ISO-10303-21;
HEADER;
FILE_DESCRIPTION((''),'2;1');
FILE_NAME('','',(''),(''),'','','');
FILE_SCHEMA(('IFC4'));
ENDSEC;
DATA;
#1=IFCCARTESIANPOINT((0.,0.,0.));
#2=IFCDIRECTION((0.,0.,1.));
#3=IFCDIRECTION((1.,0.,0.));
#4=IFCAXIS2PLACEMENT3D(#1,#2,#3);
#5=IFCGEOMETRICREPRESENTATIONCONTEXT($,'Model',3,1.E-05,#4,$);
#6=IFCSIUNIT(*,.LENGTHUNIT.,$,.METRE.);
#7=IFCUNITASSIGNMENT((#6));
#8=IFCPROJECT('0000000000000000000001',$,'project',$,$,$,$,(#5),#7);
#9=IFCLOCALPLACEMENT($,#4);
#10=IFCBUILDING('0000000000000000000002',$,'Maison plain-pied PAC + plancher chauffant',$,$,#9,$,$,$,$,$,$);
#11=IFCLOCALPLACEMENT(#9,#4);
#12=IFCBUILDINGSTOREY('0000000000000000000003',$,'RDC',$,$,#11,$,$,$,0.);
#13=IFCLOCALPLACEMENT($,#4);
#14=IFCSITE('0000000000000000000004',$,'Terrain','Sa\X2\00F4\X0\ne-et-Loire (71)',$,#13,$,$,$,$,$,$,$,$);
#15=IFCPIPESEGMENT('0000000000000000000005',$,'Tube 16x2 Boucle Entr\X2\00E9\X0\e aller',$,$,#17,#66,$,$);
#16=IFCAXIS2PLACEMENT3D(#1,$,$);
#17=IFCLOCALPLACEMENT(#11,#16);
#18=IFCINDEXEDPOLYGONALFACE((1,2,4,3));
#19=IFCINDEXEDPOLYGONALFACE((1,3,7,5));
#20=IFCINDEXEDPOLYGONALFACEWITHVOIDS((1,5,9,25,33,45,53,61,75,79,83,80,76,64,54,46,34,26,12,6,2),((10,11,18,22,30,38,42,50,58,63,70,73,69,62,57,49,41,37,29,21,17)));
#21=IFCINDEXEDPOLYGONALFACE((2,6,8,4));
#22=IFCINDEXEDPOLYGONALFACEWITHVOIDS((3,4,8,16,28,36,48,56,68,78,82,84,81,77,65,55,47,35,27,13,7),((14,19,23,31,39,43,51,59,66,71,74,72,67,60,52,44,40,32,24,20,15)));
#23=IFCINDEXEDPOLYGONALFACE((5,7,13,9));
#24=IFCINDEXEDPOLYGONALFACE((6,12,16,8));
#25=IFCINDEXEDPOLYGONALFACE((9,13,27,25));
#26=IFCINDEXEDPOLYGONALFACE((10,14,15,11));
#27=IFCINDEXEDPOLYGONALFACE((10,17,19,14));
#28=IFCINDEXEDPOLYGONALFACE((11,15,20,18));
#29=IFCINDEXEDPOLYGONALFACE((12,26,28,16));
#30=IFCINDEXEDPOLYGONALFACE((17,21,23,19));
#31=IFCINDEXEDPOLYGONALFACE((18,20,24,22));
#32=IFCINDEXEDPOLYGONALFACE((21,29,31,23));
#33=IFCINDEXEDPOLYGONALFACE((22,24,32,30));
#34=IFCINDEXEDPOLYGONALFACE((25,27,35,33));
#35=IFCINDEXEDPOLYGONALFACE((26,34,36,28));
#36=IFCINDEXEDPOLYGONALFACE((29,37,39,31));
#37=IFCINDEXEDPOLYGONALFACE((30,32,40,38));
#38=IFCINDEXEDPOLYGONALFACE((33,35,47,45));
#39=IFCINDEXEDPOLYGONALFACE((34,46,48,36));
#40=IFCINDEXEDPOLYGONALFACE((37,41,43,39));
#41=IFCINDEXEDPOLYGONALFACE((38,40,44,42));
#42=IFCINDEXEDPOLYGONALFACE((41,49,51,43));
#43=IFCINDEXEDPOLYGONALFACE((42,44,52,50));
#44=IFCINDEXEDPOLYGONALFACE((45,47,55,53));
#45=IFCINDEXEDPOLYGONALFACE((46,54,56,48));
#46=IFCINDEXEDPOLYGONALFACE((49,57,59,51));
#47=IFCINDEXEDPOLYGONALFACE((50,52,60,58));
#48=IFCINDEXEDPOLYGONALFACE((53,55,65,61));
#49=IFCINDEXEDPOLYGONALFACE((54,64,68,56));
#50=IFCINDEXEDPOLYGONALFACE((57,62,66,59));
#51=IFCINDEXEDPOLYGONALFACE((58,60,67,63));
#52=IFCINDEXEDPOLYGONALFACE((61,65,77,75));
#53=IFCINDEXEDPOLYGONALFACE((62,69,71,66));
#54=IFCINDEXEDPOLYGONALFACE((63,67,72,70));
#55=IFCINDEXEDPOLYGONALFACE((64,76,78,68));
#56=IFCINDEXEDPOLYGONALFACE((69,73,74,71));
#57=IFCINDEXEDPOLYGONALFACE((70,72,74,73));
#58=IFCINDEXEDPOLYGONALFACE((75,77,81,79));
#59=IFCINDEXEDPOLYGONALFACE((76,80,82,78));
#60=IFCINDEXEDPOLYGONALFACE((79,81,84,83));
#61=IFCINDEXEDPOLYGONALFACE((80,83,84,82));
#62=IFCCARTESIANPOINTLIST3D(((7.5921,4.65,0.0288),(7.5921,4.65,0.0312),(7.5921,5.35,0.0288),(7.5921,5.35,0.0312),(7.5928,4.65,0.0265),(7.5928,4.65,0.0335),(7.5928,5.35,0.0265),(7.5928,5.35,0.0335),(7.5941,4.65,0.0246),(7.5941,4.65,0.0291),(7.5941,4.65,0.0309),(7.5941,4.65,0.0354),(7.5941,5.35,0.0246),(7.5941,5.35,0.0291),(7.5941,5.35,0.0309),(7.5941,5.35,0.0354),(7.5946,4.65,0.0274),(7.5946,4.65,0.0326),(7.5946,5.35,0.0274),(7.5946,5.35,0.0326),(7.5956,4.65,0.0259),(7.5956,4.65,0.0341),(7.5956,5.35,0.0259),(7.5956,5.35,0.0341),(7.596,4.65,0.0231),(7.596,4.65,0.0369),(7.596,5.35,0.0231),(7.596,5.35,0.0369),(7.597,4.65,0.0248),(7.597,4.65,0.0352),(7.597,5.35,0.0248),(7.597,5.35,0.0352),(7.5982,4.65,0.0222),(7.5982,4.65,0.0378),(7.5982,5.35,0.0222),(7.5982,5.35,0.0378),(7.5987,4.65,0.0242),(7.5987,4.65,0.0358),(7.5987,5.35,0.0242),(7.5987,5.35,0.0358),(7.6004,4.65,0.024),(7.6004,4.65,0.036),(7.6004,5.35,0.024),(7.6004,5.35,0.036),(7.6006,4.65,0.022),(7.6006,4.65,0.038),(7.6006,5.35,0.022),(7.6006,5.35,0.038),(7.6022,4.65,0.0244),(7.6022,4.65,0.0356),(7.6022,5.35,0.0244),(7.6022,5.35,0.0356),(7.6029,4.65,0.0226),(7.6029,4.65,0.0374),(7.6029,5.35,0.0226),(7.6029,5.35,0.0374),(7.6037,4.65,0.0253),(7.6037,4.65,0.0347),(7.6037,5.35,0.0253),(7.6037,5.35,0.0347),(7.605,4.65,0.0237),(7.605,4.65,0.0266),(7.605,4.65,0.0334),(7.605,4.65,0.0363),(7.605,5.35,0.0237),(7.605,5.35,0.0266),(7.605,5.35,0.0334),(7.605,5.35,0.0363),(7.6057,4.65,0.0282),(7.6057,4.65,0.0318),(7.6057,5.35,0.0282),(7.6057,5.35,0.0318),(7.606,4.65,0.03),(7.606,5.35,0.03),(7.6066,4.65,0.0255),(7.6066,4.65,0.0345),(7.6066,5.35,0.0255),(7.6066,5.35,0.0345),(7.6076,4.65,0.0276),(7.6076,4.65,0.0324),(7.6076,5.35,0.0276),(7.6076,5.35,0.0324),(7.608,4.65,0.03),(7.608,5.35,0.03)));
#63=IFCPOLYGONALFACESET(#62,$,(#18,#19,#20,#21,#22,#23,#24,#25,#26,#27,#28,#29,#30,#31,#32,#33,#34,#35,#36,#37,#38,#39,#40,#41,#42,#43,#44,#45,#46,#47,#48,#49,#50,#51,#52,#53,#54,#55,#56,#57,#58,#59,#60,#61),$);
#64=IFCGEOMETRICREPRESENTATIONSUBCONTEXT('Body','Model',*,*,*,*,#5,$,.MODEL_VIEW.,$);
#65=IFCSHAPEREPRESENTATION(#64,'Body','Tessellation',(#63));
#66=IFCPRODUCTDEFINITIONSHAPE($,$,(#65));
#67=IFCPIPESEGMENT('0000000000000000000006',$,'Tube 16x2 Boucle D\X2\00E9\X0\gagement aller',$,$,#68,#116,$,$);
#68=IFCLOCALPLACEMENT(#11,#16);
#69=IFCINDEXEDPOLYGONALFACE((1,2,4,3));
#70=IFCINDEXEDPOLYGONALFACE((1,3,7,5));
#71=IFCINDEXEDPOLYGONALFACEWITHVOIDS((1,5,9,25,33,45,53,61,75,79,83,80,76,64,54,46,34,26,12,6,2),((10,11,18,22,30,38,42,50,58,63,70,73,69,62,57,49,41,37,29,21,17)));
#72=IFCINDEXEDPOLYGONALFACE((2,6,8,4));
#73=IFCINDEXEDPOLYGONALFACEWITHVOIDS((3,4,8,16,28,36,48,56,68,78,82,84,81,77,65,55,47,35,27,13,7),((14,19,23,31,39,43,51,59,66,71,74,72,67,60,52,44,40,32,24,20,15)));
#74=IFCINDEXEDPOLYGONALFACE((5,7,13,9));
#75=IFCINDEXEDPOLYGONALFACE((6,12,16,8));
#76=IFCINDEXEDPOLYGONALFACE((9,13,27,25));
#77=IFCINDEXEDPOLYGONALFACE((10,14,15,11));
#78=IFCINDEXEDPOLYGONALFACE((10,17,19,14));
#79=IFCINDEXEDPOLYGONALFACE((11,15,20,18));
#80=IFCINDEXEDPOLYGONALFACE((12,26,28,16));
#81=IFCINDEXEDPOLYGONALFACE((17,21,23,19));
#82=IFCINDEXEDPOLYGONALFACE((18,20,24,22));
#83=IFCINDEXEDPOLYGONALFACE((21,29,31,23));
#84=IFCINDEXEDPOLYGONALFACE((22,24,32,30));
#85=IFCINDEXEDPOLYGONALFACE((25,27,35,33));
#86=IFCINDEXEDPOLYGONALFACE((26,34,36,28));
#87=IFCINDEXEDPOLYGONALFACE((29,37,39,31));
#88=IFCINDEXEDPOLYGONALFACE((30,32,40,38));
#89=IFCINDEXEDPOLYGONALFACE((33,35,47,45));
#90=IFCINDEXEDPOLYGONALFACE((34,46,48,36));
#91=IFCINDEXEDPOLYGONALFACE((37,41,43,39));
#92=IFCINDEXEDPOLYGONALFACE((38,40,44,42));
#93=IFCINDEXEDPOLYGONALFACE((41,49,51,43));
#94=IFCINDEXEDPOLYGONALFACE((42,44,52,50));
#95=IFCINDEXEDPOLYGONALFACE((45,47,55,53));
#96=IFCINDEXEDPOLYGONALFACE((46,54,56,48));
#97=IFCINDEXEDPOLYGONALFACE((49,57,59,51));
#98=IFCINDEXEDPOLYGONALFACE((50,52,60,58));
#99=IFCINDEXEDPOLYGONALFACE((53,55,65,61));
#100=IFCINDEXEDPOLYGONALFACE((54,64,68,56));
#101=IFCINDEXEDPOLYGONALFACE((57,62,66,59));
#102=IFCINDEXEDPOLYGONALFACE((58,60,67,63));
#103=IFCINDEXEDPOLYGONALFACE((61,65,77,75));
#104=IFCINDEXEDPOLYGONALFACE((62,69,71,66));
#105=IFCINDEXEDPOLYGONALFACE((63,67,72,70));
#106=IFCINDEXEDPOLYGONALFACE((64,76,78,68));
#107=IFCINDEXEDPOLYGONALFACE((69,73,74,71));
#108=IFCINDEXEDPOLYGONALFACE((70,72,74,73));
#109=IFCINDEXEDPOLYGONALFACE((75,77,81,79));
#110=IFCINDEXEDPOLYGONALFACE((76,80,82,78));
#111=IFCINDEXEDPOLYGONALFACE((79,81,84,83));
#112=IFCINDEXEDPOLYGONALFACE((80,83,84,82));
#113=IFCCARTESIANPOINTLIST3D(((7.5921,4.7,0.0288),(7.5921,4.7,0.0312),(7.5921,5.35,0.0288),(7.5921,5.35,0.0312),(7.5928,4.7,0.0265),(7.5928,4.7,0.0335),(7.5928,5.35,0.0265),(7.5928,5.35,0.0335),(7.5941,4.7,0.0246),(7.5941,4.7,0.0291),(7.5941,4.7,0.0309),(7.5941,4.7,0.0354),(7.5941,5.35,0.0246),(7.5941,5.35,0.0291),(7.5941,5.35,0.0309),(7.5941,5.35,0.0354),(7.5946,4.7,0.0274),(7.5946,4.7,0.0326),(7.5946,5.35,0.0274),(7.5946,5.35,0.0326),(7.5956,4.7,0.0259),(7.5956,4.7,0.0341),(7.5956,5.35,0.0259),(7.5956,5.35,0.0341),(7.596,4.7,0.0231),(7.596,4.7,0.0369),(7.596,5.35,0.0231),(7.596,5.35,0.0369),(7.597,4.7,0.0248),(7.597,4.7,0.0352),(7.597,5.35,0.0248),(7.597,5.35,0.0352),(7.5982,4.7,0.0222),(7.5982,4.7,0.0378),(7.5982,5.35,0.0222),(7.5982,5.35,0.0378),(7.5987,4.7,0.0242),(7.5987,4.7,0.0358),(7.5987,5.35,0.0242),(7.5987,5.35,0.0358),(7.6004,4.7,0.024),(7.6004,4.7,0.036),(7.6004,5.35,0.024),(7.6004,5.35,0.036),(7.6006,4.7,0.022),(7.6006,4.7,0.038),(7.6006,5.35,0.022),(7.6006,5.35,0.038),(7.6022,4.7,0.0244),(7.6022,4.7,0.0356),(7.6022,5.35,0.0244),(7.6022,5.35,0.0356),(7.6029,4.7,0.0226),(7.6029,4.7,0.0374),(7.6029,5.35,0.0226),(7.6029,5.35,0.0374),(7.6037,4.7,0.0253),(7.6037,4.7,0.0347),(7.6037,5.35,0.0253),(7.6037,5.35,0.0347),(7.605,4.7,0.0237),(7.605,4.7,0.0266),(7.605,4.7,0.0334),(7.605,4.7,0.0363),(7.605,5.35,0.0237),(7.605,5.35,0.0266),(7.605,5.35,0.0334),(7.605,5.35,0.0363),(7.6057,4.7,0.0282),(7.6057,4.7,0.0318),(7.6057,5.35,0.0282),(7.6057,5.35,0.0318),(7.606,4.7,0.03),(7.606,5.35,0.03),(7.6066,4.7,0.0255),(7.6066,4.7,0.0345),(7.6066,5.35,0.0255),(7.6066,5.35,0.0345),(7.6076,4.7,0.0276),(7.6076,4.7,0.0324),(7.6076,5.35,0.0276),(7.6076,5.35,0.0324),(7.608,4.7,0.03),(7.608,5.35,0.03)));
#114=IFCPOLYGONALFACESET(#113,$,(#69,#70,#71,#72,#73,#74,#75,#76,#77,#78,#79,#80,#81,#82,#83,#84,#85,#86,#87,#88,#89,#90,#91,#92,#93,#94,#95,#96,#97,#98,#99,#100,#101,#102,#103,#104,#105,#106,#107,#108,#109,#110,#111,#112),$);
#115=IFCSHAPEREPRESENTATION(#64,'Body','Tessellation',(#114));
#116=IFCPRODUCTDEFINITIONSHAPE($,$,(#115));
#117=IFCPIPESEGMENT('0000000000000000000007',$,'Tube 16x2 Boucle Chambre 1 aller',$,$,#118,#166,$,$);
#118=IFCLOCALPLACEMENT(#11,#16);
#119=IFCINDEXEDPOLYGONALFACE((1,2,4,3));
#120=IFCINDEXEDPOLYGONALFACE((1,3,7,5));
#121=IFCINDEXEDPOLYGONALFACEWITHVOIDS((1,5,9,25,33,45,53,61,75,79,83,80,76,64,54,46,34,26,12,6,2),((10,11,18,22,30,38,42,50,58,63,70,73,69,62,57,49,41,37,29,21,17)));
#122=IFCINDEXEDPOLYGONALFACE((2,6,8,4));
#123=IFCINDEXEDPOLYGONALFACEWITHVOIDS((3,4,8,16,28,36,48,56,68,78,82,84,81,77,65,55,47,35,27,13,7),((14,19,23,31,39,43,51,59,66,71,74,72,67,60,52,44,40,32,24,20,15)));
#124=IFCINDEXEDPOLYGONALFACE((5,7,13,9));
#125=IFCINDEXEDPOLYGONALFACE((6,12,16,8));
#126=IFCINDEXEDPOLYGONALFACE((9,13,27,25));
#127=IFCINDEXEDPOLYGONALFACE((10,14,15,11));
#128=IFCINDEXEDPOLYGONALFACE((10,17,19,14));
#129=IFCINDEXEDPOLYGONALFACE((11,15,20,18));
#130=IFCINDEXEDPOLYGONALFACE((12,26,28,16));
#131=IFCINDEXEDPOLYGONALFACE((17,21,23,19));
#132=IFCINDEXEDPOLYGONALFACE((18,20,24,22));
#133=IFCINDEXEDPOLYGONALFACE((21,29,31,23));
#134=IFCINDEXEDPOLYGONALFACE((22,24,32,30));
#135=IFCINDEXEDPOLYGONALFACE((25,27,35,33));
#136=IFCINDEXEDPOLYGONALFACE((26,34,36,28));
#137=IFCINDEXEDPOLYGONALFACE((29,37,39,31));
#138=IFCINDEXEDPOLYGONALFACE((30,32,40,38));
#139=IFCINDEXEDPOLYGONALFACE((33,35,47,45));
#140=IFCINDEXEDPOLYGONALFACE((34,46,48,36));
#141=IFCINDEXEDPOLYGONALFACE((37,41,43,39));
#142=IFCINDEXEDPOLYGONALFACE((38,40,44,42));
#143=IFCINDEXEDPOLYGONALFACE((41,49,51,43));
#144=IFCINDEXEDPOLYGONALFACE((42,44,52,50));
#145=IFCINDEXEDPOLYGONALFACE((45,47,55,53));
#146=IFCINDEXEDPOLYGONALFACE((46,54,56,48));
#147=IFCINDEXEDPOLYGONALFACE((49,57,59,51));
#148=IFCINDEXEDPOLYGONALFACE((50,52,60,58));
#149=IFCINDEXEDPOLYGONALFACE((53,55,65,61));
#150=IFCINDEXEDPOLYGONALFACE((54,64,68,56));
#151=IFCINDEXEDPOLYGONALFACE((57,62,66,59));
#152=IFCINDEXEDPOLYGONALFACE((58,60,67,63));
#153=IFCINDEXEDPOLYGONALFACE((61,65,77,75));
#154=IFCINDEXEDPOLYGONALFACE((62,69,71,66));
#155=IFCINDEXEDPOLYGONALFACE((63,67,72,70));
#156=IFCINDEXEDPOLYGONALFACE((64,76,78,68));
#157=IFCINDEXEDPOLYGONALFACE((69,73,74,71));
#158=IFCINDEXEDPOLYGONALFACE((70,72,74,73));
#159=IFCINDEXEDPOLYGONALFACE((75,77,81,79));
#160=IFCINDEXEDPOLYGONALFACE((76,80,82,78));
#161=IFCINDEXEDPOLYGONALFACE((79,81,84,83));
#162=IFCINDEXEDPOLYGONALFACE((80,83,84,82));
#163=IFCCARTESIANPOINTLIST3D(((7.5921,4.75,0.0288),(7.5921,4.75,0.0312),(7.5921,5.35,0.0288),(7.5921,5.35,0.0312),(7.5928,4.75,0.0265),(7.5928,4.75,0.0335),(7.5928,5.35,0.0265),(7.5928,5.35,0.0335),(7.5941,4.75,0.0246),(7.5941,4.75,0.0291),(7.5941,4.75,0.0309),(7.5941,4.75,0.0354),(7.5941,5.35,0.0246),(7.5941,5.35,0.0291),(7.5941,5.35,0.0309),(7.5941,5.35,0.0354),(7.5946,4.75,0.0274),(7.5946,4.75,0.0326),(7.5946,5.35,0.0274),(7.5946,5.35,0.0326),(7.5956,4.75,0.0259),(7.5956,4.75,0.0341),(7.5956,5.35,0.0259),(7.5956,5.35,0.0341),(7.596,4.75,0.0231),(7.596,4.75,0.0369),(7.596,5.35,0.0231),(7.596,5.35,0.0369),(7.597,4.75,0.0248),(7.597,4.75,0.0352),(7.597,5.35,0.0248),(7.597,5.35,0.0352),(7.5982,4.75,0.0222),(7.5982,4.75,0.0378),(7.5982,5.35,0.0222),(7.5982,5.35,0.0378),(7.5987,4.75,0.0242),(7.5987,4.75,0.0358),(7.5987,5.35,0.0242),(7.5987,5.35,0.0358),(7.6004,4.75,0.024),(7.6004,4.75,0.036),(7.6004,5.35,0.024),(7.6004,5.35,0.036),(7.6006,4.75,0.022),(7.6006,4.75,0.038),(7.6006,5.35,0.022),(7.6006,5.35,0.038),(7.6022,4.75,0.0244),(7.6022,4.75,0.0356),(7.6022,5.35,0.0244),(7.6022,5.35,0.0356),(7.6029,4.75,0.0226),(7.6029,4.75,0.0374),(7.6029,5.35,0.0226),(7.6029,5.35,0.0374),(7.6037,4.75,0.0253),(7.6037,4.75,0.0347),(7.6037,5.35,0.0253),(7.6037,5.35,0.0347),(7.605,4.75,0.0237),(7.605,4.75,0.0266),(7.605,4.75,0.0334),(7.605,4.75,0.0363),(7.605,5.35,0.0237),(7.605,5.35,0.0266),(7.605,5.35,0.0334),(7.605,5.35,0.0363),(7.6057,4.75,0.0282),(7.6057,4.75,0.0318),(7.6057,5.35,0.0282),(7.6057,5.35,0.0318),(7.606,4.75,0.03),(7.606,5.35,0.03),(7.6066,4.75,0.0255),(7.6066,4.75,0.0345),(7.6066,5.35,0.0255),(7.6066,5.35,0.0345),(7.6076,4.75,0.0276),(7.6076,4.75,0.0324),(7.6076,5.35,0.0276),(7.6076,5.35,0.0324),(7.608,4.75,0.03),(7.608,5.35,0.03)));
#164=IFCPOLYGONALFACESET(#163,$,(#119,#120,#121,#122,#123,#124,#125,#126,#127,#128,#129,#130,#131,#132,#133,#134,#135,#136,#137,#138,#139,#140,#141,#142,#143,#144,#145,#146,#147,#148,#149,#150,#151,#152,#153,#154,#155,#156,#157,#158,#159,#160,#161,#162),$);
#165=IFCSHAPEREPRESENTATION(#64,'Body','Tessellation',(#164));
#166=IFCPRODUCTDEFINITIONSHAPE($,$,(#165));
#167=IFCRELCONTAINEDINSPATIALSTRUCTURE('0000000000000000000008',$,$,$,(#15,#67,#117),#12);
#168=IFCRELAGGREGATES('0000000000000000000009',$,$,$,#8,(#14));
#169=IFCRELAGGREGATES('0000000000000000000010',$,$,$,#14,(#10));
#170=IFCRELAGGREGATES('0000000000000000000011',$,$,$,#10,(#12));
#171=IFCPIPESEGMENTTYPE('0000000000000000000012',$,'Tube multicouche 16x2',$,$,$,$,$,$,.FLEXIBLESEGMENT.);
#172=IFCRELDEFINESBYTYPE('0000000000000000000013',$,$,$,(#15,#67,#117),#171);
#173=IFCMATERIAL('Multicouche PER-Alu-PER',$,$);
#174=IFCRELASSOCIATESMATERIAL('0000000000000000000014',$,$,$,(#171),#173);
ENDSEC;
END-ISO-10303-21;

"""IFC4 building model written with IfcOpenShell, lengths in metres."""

from ifc_helpers import new_model, si_unit, frame, origin_with_axes, place, context, subcontext, project, spatial, hollow_circle, extrude, material, type_object, element, save


model = new_model("IFC4")

# Units and contexts
model_context = context("Model", 3, precision=1e-05, world=origin_with_axes())
body_context = subcontext(model_context, "Body", "Model", "MODEL_VIEW")
ifc_project = project(units=[si_unit("LENGTHUNIT", "METRE")], contexts=[model_context])

# Site, building, storey
site_placement = place(None, origin_with_axes())
site = spatial("IfcSite", under=ifc_project, at=site_placement, Name="Terrain", Description="Saône-et-Loire (71)")
building_placement = place(None, origin_with_axes())
building = spatial("IfcBuilding", under=site, at=building_placement, Name="Maison plain-pied PAC + plancher chauffant")
storey_placement = place(building_placement, origin_with_axes())
storey = spatial("IfcBuildingStorey", under=building, at=storey_placement, Name="RDC", Elevation=0.0)

# Pipe segments
ifc_material_1 = material(Name="Multicouche PER-Alu-PER")
pipe_segment_type_1 = type_object("IfcPipeSegmentType", Name="Tube multicouche 16x2", PredefinedType="FLEXIBLESEGMENT", material=ifc_material_1)
pipe_segment_1_placement = place(storey_placement, frame((7.6, 5.35, 0.03), z_axis=(0.0, -1.0, 0.0), x_axis=(1.0, 0.0, 0.0)))
element("IfcPipeSegment", 1, at=pipe_segment_1_placement, inside=storey, type_object=pipe_segment_type_1, Name="Tube 16x2 Boucle Entrée aller", context=body_context, shape_type="SweptSolid", body=[
    extrude(hollow_circle(Radius=0.008, WallThickness=0.002), origin_with_axes(), (0.0, 0.0, 1.0), 0.7),
])
pipe_segment_2_placement = place(storey_placement, frame((7.6, 5.35, 0.03), z_axis=(0.0, -1.0, 0.0), x_axis=(1.0, 0.0, 0.0)))
element("IfcPipeSegment", 2, at=pipe_segment_2_placement, inside=storey, type_object=pipe_segment_type_1, Name="Tube 16x2 Boucle Dégagement aller", context=body_context, shape_type="SweptSolid", body=[
    extrude(hollow_circle(Radius=0.008, WallThickness=0.002), origin_with_axes(), (0.0, 0.0, 1.0), 0.65),
])
pipe_segment_3_placement = place(storey_placement, frame((7.6, 5.35, 0.03), z_axis=(0.0, -1.0, 0.0), x_axis=(1.0, 0.0, 0.0)))
element("IfcPipeSegment", 3, at=pipe_segment_3_placement, inside=storey, type_object=pipe_segment_type_1, Name="Tube 16x2 Boucle Chambre 1 aller", context=body_context, shape_type="SweptSolid", body=[
    extrude(hollow_circle(Radius=0.008, WallThickness=0.002), origin_with_axes(), (0.0, 0.0, 1.0), 0.6),
])

save(model, "model.ifc")
